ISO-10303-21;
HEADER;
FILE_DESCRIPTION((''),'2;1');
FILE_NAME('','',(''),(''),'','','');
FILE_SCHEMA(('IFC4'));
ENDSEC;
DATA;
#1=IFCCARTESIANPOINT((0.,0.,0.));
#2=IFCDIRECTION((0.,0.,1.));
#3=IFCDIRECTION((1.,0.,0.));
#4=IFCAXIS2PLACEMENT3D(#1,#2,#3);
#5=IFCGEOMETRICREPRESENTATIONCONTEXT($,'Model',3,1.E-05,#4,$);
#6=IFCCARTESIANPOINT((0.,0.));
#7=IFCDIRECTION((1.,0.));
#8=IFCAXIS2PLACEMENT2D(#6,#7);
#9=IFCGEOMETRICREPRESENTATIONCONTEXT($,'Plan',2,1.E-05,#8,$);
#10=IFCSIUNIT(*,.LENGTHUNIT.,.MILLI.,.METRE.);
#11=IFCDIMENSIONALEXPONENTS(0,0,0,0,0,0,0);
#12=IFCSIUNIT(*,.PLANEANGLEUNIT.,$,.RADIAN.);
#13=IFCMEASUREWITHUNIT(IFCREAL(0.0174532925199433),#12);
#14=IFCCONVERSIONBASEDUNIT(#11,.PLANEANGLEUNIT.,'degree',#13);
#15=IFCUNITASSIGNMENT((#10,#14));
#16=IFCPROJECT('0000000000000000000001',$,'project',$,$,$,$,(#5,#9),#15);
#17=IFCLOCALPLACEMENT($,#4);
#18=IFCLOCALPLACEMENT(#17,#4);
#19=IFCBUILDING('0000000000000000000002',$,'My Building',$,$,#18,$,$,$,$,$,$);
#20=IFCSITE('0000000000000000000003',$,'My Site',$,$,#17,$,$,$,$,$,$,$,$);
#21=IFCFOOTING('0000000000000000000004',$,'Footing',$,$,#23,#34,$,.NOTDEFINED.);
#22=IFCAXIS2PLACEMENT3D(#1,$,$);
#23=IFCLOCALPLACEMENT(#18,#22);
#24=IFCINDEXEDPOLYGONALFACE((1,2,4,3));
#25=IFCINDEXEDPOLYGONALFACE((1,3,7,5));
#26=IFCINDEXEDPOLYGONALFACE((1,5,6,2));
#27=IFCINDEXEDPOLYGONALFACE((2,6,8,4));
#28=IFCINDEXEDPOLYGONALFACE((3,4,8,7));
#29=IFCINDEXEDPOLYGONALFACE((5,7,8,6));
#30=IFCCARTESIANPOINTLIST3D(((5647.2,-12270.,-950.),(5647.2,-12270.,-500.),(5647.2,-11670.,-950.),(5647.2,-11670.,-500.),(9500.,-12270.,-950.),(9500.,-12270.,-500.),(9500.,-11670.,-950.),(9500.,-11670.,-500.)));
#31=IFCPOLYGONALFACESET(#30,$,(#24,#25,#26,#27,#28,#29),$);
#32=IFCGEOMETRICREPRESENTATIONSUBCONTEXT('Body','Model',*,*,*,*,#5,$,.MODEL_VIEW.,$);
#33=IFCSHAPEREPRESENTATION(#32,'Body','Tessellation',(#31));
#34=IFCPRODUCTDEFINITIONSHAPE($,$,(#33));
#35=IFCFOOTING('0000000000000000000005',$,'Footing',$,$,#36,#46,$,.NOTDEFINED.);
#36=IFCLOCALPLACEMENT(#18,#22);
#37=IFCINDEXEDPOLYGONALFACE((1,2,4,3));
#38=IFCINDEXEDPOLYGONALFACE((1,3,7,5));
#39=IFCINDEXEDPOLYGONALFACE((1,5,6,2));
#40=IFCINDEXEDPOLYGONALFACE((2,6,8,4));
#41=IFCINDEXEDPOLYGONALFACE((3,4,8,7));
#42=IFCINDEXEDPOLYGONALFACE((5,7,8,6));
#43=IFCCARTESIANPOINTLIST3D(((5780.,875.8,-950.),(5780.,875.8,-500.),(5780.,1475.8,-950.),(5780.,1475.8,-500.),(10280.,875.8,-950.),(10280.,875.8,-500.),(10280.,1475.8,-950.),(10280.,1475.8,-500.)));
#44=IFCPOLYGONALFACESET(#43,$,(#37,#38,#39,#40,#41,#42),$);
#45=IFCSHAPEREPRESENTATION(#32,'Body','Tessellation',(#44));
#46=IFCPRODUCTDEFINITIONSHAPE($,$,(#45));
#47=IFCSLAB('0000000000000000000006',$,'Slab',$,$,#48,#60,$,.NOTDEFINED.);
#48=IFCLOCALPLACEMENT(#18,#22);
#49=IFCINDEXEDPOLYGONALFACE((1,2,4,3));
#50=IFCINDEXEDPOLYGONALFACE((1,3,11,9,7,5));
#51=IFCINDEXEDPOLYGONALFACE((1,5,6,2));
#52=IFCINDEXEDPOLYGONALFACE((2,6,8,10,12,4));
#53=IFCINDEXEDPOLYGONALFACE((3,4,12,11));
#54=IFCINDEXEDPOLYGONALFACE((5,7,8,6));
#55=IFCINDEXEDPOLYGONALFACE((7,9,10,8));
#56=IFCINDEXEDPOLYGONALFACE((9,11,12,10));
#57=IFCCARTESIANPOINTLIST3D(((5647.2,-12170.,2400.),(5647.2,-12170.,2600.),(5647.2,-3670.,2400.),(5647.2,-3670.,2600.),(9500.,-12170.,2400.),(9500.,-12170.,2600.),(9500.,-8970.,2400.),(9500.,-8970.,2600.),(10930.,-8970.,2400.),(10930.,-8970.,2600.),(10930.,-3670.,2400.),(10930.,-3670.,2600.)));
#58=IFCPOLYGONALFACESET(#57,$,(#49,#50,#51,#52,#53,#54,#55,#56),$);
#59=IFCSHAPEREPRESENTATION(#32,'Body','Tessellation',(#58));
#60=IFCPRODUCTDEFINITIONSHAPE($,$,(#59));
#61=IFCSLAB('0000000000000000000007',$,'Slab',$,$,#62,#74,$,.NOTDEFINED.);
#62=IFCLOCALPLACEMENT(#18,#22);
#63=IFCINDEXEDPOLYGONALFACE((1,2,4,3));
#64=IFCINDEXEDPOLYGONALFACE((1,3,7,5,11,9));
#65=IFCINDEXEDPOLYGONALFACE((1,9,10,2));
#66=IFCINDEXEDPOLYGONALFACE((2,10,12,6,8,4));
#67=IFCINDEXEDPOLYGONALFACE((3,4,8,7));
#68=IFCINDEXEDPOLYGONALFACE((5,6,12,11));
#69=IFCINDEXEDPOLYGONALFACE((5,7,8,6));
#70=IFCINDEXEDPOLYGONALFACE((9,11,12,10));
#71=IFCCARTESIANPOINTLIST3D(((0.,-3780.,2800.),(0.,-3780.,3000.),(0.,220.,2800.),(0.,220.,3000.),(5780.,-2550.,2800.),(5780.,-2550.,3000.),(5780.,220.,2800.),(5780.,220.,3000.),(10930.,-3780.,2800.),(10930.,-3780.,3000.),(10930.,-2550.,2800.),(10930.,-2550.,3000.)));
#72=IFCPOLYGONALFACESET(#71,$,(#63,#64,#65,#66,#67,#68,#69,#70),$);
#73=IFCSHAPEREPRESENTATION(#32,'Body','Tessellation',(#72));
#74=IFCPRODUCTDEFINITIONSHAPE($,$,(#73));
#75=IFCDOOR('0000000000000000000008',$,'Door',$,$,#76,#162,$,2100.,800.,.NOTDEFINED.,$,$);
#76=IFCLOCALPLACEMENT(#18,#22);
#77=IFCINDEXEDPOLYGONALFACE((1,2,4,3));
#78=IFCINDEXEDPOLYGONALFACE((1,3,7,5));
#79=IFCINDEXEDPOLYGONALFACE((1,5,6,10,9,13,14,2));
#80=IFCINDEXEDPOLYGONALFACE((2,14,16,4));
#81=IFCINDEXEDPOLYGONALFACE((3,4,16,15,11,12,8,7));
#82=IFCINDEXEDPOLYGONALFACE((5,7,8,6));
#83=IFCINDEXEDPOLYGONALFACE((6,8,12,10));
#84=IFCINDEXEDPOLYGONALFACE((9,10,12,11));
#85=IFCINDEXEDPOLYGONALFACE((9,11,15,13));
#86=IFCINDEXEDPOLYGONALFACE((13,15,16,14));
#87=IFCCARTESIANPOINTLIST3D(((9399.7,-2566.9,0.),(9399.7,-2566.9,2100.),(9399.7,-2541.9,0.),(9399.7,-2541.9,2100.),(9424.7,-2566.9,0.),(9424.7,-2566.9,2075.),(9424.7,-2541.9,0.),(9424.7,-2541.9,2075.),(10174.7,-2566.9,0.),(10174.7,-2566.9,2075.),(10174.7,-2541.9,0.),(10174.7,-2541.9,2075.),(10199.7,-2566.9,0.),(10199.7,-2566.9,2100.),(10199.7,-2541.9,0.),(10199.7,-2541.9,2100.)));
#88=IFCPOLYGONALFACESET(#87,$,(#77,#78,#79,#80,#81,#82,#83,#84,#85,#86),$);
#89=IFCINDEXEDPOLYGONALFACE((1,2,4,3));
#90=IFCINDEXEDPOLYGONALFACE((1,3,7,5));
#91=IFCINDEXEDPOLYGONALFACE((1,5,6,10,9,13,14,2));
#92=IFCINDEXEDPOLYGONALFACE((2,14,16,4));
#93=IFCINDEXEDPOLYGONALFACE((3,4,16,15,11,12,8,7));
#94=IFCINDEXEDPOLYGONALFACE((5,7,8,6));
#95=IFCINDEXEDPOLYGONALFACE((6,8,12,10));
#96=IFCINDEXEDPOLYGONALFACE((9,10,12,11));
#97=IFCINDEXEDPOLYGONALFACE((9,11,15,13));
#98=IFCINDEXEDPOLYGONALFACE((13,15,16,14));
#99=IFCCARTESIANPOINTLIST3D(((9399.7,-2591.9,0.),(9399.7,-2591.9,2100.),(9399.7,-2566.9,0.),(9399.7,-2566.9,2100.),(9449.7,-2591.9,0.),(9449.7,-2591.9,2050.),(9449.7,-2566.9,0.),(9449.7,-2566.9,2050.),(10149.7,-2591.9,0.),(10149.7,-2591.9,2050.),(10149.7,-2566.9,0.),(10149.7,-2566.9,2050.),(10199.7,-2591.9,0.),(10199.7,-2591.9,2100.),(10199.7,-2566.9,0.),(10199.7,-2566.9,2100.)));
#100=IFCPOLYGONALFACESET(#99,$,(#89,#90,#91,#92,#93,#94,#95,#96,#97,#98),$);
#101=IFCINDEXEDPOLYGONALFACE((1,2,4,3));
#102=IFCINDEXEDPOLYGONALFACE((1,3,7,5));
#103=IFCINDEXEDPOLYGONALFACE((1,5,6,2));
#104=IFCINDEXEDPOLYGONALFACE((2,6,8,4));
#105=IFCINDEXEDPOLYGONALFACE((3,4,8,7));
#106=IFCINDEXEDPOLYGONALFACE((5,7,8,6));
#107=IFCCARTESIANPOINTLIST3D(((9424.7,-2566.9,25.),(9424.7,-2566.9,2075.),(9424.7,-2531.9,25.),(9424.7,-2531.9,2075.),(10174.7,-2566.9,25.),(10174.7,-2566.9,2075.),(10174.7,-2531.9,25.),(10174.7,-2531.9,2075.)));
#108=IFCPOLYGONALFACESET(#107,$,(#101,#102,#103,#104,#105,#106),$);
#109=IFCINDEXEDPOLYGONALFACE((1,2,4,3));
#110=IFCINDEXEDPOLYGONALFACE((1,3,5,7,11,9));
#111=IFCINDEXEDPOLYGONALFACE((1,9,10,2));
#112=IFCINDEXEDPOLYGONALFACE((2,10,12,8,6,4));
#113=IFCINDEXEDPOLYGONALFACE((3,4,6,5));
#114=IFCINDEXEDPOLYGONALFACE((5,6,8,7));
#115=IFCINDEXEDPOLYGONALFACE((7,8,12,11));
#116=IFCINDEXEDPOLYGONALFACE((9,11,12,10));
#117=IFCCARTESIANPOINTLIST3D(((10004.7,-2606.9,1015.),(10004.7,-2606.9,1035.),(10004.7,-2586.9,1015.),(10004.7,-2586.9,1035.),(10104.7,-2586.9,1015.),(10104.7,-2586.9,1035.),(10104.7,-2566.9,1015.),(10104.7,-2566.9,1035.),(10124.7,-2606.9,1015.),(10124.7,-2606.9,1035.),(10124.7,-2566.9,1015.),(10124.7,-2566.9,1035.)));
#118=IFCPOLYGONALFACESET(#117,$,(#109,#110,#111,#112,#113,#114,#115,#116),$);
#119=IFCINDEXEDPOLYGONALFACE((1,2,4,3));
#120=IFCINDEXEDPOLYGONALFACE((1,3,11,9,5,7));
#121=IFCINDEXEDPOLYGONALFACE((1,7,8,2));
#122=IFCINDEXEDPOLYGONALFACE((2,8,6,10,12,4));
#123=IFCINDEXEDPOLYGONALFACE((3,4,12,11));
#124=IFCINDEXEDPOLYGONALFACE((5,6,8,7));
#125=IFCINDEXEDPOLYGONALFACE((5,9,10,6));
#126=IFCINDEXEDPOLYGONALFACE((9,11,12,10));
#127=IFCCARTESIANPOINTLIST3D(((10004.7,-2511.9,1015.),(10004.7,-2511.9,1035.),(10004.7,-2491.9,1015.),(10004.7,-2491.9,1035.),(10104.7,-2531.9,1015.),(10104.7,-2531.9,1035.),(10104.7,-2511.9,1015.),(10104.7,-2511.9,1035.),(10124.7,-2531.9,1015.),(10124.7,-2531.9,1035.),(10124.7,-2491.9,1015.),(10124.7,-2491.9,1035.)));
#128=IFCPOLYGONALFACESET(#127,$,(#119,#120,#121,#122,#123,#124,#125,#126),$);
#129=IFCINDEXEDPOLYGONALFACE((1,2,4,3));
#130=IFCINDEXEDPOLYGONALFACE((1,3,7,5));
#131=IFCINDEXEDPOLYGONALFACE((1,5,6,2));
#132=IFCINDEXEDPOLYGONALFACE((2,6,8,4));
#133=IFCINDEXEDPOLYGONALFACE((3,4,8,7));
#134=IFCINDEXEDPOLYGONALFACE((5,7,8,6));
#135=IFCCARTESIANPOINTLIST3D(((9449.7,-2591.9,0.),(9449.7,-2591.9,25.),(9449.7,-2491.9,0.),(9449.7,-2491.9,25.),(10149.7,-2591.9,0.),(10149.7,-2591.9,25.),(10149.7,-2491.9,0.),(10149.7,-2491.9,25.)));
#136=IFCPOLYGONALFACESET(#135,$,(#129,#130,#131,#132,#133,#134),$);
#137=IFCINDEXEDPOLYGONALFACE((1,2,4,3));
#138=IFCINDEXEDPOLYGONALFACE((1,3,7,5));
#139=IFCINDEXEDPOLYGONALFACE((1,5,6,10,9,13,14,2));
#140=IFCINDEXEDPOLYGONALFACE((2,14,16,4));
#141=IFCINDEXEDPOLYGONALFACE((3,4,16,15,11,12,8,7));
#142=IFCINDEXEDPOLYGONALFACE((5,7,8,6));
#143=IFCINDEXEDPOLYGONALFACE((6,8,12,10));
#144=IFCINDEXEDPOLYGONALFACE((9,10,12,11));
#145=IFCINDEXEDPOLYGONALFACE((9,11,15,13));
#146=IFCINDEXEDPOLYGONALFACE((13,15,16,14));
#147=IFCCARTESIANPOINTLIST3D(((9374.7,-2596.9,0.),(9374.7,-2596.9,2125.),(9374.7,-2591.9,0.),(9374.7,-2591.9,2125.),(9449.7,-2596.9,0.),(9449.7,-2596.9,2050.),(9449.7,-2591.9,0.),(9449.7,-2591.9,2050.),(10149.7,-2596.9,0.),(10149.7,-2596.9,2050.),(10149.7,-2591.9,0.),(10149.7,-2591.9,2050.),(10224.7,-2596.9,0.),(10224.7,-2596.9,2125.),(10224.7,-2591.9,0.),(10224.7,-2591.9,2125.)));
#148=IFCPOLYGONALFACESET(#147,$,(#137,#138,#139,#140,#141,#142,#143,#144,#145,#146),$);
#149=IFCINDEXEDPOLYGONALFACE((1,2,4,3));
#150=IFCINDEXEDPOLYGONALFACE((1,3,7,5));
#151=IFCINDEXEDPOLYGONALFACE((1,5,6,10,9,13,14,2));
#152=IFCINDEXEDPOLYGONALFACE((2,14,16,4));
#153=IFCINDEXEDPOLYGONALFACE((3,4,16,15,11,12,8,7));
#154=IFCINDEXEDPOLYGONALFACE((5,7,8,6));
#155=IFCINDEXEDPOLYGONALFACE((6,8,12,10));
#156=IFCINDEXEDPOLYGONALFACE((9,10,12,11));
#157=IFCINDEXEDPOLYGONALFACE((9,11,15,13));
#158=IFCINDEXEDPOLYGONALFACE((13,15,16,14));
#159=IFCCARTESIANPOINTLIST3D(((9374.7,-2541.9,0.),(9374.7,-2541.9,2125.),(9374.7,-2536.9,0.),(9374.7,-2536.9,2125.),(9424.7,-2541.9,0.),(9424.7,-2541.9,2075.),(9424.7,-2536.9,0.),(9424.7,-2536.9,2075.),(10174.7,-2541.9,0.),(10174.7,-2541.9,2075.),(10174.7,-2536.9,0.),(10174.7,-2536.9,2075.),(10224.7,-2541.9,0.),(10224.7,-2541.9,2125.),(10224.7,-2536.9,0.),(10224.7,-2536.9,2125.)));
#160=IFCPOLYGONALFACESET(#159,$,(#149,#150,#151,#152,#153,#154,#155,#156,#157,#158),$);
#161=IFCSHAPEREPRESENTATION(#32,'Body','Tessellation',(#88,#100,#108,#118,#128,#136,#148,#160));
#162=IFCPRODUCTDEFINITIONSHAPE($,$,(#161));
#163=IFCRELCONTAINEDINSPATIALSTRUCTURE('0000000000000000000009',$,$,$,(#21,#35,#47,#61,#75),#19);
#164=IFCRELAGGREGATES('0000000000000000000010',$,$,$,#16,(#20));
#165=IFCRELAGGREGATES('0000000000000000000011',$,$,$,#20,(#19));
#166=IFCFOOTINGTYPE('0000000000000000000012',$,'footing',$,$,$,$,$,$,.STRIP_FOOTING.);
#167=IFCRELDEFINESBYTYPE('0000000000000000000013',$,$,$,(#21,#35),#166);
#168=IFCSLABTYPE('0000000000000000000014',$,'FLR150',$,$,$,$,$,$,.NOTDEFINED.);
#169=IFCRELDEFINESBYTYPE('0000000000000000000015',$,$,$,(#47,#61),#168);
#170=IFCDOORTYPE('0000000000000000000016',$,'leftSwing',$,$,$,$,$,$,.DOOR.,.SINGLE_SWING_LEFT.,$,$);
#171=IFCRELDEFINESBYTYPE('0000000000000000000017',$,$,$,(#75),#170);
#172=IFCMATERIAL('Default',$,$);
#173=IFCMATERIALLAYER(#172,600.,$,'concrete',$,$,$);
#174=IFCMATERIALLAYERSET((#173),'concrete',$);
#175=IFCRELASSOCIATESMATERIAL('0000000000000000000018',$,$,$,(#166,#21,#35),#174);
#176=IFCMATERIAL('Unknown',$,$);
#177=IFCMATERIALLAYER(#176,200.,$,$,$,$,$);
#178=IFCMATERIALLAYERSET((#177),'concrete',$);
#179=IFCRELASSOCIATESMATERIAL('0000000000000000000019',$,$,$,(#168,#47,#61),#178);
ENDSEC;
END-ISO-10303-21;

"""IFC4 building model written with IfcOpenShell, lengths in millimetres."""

from ifc_helpers import new_model, entity, si_unit, converted_unit, frame, origin_with_axes, origin_2d_with_axis, place, context, subcontext, project, spatial, line, indexed_curve, outline, extrude, shape, source, transform, mapped, material, layer, layer_set, layer_usage, type_object, type_shapes, element, save


model = new_model("IFC4")

# Units and contexts
model_context = context("Model", 3, precision=1e-05, world=origin_with_axes())
plan_context = context("Plan", 2, precision=1e-05, world=origin_2d_with_axis())
body_context_1 = subcontext(model_context, "Body", "Model", "MODEL_VIEW")
body_context_2 = subcontext(plan_context, "Body", "Plan", "PLAN_VIEW")
ifc_project = project(units=[si_unit("LENGTHUNIT", "METRE", prefix="MILLI"), converted_unit("PLANEANGLEUNIT", "degree", entity("IfcReal", 0.0174532925199433), si_unit("PLANEANGLEUNIT", "RADIAN"), dimensions=[0, 0, 0, 0, 0, 0, 0])], contexts=[model_context, plan_context])

# Site, building
site_placement = place(None, origin_with_axes())
site = spatial("IfcSite", under=ifc_project, at=site_placement, Name="My Site")
building_placement = place(site_placement, origin_with_axes())
building = spatial("IfcBuilding", under=site, at=building_placement, Name="My Building")

# Footings
ifc_material_1 = material(Name="Default")
ifc_layer_1 = layer(ifc_material_1, 600.0, Name="concrete")
ifc_layer_set_1 = layer_set([ifc_layer_1], Name="concrete")
ifc_layer_usage_1 = layer_usage(ifc_layer_set_1, "AXIS2", "POSITIVE", 0.0)
footing_type = type_object("IfcFootingType", Name="footing", PredefinedType="STRIP_FOOTING", material=ifc_layer_set_1)
footing_1_placement = place(building_placement, frame((5647.2, -12270.0, -950.0), z_axis=(0.0, 0.0, 1.0), x_axis=(1.0, 0.0, 0.0)))
element("IfcFooting", 1, at=footing_1_placement, inside=building, type_object=footing_type, material=ifc_layer_usage_1, Name="Footing", PredefinedType="NOTDEFINED", context=body_context_1, shape_type="SweptSolid", body=[
    extrude(outline(indexed_curve([(0.0, 0.0), (0.0, 600.0), (3852.8, 600.0), (3852.8, 0.0), (0.0, 0.0)], self_intersect=False)), origin_with_axes(), (0.0, 0.0, 1.0), 450.0),
])
ifc_layer_usage_2 = layer_usage(ifc_layer_set_1, "AXIS2", "POSITIVE", 0.0)
footing_2_placement = place(building_placement, frame((5780.0, 875.8, -950.0), z_axis=(0.0, 0.0, 1.0), x_axis=(1.0, 0.0, 0.0)))
element("IfcFooting", 2, at=footing_2_placement, inside=building, type_object=footing_type, material=ifc_layer_usage_2, Name="Footing", PredefinedType="NOTDEFINED", context=body_context_1, shape_type="SweptSolid", body=[
    extrude(outline(indexed_curve([(0.0, 0.0), (0.0, 600.0), (4500.0, 600.0), (4500.0, 0.0), (0.0, 0.0)], self_intersect=False)), origin_with_axes(), (0.0, 0.0, 1.0), 450.0),
])

# Slabs
ifc_material_2 = material(Name="Unknown")
ifc_layer_2 = layer(ifc_material_2, 200.0)
ifc_layer_set_2 = layer_set([ifc_layer_2], Name="concrete")
slab_type_1 = type_object("IfcSlabType", Name="FLR150", PredefinedType="NOTDEFINED", material=ifc_layer_set_2)
ifc_layer_usage_3 = layer_usage(ifc_layer_set_2, "AXIS3", "POSITIVE", 0.0)
slab_1_placement = place(building_placement, frame((5647.2, -12170.0, 2400.0), z_axis=(0.0, 0.0, 1.0), x_axis=(1.0, 0.0, 0.0)))
element("IfcSlab", 3, at=slab_1_placement, inside=building, type_object=slab_type_1, material=ifc_layer_usage_3, Name="Slab", PredefinedType="NOTDEFINED", context=body_context_1, shape_type="SweptSolid", body=[
    extrude(outline(indexed_curve([(5282.8, 8500.0), (0.0, 8500.0), (0.0, 0.0), (3852.8, 0.0), (3852.8, 3200.0), (5282.8, 3200.0)], segments=[line(4, 3), line(3, 2), line(2, 1), line(1, 6), line(6, 5), line(5, 4)], self_intersect=False)), None, (0.0, 0.0, 1.0), 200.0),
])
ifc_layer_usage_4 = layer_usage(ifc_layer_set_2, "AXIS3", "POSITIVE", 0.0)
slab_2_placement = place(building_placement, frame((0.0, -3780.0, 2800.0), z_axis=(0.0, 0.0, 1.0), x_axis=(1.0, 0.0, 0.0)))
element("IfcSlab", 4, at=slab_2_placement, inside=building, type_object=slab_type_1, material=ifc_layer_usage_4, Name="Slab", PredefinedType="NOTDEFINED", context=body_context_1, shape_type="SweptSolid", body=[
    extrude(outline(indexed_curve([(5780.0, 1230.0), (5780.0, 4000.0), (0.0, 4000.0), (0.0, 0.0), (10930.0, 0.0), (10930.0, 1230.0)], segments=[line(1, 6), line(6, 5), line(5, 4), line(4, 3), line(3, 2), line(2, 1)], self_intersect=False)), None, (0.0, 0.0, 1.0), 200.0),
])

# Door
door_type = type_object("IfcDoorType", Name="leftSwing", OperationType="SINGLE_SWING_LEFT", PredefinedType="DOOR")
shared_shape_1 = source(origin_with_axes(), body_context_1, "Body", "SweptSolid", [
    extrude(outline(indexed_curve([(0.0, 0.0, 0.0), (0.0, 0.0, 2100.0), (800.0, 0.0, 2100.0), (800.0, 0.0, 0.0), (775.0, 0.0, 0.0), (775.0, 0.0, 2075.0), (25.0, 0.0, 2075.0), (25.0, 0.0, 0.0)], segments=[line(1, 2), line(2, 3), line(3, 4), line(4, 5), line(5, 6), line(6, 7), line(7, 8), line(8, 1)])), frame((0.0, 25.0, 0.0), z_axis=(0.0, 0.0, 1.0), x_axis=(1.0, 0.0, 0.0)), (0.0, 1.0, 0.0), 25.0),
    extrude(outline(indexed_curve([(0.0, 0.0, 0.0), (0.0, 0.0, 2100.0), (800.0, 0.0, 2100.0), (800.0, 0.0, 0.0), (750.0, 0.0, 0.0), (750.0, 0.0, 2050.0), (50.0, 0.0, 2050.0), (50.0, 0.0, 0.0)], segments=[line(1, 2), line(2, 3), line(3, 4), line(4, 5), line(5, 6), line(6, 7), line(7, 8), line(8, 1)])), origin_with_axes(), (0.0, 1.0, 0.0), 25.0),
    extrude(outline(indexed_curve([(0.0, 0.0), (750.0, 0.0), (750.0, 35.0), (0.0, 35.0)], segments=[line(1, 2), line(2, 3), line(3, 4), line(4, 1)])), frame((25.0, 25.0, 25.0), z_axis=(0.0, 0.0, 1.0), x_axis=(1.0, 0.0, 0.0)), (0.0, 0.0, 1.0), 2050.0),
    extrude(outline(indexed_curve([(0.0, 0.0), (0.0, -40.0), (-120.0, -40.0), (-120.0, -20.0), (-20.0, -20.0), (-20.0, 0.0)], segments=[line(1, 2), line(2, 3), line(3, 4), line(4, 5), line(5, 6), line(6, 1)])), frame((725.0, 25.0, 1015.0), z_axis=(0.0, 0.0, 1.0), x_axis=(1.0, 0.0, 0.0)), (0.0, 0.0, 1.0), 20.0),
    extrude(outline(indexed_curve([(0.0, 0.0), (0.0, 40.0), (-120.0, 40.0), (-120.0, 20.0), (-20.0, 20.0), (-20.0, 0.0)], segments=[line(1, 2), line(2, 3), line(3, 4), line(4, 5), line(5, 6), line(6, 1)])), frame((725.0, 60.0, 1015.0), z_axis=(0.0, 0.0, 1.0), x_axis=(1.0, 0.0, 0.0)), (0.0, 0.0, 1.0), 20.0),
    extrude(outline(indexed_curve([(0.0, 0.0), (700.0, 0.0), (700.0, 100.0), (0.0, 100.0)], segments=[line(1, 2), line(2, 3), line(3, 4), line(4, 1)])), frame((50.0, 0.0, 0.0), z_axis=(0.0, 0.0, 1.0), x_axis=(1.0, 0.0, 0.0)), (0.0, 0.0, 1.0), 25.0),
    extrude(outline(indexed_curve([(0.0, 0.0, 0.0), (0.0, 0.0, 2125.0), (850.0, 0.0, 2125.0), (850.0, 0.0, 0.0), (775.0, 0.0, 0.0), (775.0, 0.0, 2050.0), (75.0, 0.0, 2050.0), (75.0, 0.0, 0.0)], segments=[line(1, 2), line(2, 3), line(3, 4), line(4, 5), line(5, 6), line(6, 7), line(7, 8), line(8, 1)])), frame((-25.0, -5.0, 0.0), z_axis=(0.0, 0.0, 1.0), x_axis=(1.0, 0.0, 0.0)), (0.0, 1.0, 0.0), 5.0),
    extrude(outline(indexed_curve([(0.0, 0.0, 0.0), (0.0, 0.0, 2125.0), (850.0, 0.0, 2125.0), (850.0, 0.0, 0.0), (800.0, 0.0, 0.0), (800.0, 0.0, 2075.0), (50.0, 0.0, 2075.0), (50.0, 0.0, 0.0)], segments=[line(1, 2), line(2, 3), line(3, 4), line(4, 5), line(5, 6), line(6, 7), line(7, 8), line(8, 1)])), frame((-25.0, 50.0, 0.0), z_axis=(0.0, 0.0, 1.0), x_axis=(1.0, 0.0, 0.0)), (0.0, 1.0, 0.0), 5.0),
])
shared_shape_2 = source(origin_with_axes(), body_context_2, "Body", "Curve2D", [
    entity("IfcIndexedPolyCurve", entity("IfcCartesianPointList2D", [[0.0, 0.0], [0.0, 50.0], [25.0, 50.0], [25.0, 25.0], [50.0, 25.0], [50.0, 0.0]]), [entity("IfcLineIndex", [1, 2]), entity("IfcLineIndex", [2, 3]), entity("IfcLineIndex", [3, 4]), entity("IfcLineIndex", [4, 5]), entity("IfcLineIndex", [5, 6]), entity("IfcLineIndex", [6, 1])]),
    entity("IfcIndexedPolyCurve", entity("IfcCartesianPointList2D", [[800.0, 0.0], [800.0, 50.0], [775.0, 50.0], [775.0, 25.0], [750.0, 25.0], [750.0, 0.0]]), [entity("IfcLineIndex", [1, 2]), entity("IfcLineIndex", [2, 3]), entity("IfcLineIndex", [3, 4]), entity("IfcLineIndex", [4, 5]), entity("IfcLineIndex", [5, 6]), entity("IfcLineIndex", [6, 1])]),
    entity("IfcTrimmedCurve", entity("IfcEllipse", entity("IfcAxis2Placement2D", entity("IfcCartesianPoint", [60.0, 50.0]), entity("IfcDirection", [1.0, 0.0])), 715.0, 750.0), [entity("IfcCartesianPoint", [775.0, 50.0])], [entity("IfcCartesianPoint", [60.0, 800.0])], True, "CARTESIAN"),
    entity("IfcIndexedPolyCurve", entity("IfcCartesianPointList2D", [[25.0, 50.0], [60.0, 50.0], [60.0, 800.0], [25.0, 800.0]]), [entity("IfcLineIndex", [1, 2]), entity("IfcLineIndex", [2, 3]), entity("IfcLineIndex", [3, 4]), entity("IfcLineIndex", [4, 1])]),
])
type_shapes(door_type, [shared_shape_1, shared_shape_2])
door_placement = place(building_placement, frame((9399.7, -2591.9, 0.0), z_axis=(0.0, 0.0, 1.0), x_axis=(1.0, 0.0, 0.0)))
element("IfcDoor", 5, at=door_placement, inside=building, type_object=door_type, Name="Door", OverallHeight=2100.0, OverallWidth=800.0, PredefinedType="NOTDEFINED", shapes=[
    shape(body_context_1, "Body", "MappedRepresentation", [mapped(shared_shape_1, transform((0.0, 0.0, 0.0), x_axis=(1.0, 0.0, 0.0), y_axis=(0.0, 1.0, 0.0), z_axis=(0.0, 0.0, 1.0), scale=1.0))]),
    shape(body_context_2, "Body", "MappedRepresentation", [mapped(shared_shape_2, transform((0.0, 0.0, 0.0), x_axis=(1.0, 0.0, 0.0), y_axis=(0.0, 1.0, 0.0), z_axis=(0.0, 0.0, 1.0), scale=1.0))]),
])

save(model, "model.ifc")
